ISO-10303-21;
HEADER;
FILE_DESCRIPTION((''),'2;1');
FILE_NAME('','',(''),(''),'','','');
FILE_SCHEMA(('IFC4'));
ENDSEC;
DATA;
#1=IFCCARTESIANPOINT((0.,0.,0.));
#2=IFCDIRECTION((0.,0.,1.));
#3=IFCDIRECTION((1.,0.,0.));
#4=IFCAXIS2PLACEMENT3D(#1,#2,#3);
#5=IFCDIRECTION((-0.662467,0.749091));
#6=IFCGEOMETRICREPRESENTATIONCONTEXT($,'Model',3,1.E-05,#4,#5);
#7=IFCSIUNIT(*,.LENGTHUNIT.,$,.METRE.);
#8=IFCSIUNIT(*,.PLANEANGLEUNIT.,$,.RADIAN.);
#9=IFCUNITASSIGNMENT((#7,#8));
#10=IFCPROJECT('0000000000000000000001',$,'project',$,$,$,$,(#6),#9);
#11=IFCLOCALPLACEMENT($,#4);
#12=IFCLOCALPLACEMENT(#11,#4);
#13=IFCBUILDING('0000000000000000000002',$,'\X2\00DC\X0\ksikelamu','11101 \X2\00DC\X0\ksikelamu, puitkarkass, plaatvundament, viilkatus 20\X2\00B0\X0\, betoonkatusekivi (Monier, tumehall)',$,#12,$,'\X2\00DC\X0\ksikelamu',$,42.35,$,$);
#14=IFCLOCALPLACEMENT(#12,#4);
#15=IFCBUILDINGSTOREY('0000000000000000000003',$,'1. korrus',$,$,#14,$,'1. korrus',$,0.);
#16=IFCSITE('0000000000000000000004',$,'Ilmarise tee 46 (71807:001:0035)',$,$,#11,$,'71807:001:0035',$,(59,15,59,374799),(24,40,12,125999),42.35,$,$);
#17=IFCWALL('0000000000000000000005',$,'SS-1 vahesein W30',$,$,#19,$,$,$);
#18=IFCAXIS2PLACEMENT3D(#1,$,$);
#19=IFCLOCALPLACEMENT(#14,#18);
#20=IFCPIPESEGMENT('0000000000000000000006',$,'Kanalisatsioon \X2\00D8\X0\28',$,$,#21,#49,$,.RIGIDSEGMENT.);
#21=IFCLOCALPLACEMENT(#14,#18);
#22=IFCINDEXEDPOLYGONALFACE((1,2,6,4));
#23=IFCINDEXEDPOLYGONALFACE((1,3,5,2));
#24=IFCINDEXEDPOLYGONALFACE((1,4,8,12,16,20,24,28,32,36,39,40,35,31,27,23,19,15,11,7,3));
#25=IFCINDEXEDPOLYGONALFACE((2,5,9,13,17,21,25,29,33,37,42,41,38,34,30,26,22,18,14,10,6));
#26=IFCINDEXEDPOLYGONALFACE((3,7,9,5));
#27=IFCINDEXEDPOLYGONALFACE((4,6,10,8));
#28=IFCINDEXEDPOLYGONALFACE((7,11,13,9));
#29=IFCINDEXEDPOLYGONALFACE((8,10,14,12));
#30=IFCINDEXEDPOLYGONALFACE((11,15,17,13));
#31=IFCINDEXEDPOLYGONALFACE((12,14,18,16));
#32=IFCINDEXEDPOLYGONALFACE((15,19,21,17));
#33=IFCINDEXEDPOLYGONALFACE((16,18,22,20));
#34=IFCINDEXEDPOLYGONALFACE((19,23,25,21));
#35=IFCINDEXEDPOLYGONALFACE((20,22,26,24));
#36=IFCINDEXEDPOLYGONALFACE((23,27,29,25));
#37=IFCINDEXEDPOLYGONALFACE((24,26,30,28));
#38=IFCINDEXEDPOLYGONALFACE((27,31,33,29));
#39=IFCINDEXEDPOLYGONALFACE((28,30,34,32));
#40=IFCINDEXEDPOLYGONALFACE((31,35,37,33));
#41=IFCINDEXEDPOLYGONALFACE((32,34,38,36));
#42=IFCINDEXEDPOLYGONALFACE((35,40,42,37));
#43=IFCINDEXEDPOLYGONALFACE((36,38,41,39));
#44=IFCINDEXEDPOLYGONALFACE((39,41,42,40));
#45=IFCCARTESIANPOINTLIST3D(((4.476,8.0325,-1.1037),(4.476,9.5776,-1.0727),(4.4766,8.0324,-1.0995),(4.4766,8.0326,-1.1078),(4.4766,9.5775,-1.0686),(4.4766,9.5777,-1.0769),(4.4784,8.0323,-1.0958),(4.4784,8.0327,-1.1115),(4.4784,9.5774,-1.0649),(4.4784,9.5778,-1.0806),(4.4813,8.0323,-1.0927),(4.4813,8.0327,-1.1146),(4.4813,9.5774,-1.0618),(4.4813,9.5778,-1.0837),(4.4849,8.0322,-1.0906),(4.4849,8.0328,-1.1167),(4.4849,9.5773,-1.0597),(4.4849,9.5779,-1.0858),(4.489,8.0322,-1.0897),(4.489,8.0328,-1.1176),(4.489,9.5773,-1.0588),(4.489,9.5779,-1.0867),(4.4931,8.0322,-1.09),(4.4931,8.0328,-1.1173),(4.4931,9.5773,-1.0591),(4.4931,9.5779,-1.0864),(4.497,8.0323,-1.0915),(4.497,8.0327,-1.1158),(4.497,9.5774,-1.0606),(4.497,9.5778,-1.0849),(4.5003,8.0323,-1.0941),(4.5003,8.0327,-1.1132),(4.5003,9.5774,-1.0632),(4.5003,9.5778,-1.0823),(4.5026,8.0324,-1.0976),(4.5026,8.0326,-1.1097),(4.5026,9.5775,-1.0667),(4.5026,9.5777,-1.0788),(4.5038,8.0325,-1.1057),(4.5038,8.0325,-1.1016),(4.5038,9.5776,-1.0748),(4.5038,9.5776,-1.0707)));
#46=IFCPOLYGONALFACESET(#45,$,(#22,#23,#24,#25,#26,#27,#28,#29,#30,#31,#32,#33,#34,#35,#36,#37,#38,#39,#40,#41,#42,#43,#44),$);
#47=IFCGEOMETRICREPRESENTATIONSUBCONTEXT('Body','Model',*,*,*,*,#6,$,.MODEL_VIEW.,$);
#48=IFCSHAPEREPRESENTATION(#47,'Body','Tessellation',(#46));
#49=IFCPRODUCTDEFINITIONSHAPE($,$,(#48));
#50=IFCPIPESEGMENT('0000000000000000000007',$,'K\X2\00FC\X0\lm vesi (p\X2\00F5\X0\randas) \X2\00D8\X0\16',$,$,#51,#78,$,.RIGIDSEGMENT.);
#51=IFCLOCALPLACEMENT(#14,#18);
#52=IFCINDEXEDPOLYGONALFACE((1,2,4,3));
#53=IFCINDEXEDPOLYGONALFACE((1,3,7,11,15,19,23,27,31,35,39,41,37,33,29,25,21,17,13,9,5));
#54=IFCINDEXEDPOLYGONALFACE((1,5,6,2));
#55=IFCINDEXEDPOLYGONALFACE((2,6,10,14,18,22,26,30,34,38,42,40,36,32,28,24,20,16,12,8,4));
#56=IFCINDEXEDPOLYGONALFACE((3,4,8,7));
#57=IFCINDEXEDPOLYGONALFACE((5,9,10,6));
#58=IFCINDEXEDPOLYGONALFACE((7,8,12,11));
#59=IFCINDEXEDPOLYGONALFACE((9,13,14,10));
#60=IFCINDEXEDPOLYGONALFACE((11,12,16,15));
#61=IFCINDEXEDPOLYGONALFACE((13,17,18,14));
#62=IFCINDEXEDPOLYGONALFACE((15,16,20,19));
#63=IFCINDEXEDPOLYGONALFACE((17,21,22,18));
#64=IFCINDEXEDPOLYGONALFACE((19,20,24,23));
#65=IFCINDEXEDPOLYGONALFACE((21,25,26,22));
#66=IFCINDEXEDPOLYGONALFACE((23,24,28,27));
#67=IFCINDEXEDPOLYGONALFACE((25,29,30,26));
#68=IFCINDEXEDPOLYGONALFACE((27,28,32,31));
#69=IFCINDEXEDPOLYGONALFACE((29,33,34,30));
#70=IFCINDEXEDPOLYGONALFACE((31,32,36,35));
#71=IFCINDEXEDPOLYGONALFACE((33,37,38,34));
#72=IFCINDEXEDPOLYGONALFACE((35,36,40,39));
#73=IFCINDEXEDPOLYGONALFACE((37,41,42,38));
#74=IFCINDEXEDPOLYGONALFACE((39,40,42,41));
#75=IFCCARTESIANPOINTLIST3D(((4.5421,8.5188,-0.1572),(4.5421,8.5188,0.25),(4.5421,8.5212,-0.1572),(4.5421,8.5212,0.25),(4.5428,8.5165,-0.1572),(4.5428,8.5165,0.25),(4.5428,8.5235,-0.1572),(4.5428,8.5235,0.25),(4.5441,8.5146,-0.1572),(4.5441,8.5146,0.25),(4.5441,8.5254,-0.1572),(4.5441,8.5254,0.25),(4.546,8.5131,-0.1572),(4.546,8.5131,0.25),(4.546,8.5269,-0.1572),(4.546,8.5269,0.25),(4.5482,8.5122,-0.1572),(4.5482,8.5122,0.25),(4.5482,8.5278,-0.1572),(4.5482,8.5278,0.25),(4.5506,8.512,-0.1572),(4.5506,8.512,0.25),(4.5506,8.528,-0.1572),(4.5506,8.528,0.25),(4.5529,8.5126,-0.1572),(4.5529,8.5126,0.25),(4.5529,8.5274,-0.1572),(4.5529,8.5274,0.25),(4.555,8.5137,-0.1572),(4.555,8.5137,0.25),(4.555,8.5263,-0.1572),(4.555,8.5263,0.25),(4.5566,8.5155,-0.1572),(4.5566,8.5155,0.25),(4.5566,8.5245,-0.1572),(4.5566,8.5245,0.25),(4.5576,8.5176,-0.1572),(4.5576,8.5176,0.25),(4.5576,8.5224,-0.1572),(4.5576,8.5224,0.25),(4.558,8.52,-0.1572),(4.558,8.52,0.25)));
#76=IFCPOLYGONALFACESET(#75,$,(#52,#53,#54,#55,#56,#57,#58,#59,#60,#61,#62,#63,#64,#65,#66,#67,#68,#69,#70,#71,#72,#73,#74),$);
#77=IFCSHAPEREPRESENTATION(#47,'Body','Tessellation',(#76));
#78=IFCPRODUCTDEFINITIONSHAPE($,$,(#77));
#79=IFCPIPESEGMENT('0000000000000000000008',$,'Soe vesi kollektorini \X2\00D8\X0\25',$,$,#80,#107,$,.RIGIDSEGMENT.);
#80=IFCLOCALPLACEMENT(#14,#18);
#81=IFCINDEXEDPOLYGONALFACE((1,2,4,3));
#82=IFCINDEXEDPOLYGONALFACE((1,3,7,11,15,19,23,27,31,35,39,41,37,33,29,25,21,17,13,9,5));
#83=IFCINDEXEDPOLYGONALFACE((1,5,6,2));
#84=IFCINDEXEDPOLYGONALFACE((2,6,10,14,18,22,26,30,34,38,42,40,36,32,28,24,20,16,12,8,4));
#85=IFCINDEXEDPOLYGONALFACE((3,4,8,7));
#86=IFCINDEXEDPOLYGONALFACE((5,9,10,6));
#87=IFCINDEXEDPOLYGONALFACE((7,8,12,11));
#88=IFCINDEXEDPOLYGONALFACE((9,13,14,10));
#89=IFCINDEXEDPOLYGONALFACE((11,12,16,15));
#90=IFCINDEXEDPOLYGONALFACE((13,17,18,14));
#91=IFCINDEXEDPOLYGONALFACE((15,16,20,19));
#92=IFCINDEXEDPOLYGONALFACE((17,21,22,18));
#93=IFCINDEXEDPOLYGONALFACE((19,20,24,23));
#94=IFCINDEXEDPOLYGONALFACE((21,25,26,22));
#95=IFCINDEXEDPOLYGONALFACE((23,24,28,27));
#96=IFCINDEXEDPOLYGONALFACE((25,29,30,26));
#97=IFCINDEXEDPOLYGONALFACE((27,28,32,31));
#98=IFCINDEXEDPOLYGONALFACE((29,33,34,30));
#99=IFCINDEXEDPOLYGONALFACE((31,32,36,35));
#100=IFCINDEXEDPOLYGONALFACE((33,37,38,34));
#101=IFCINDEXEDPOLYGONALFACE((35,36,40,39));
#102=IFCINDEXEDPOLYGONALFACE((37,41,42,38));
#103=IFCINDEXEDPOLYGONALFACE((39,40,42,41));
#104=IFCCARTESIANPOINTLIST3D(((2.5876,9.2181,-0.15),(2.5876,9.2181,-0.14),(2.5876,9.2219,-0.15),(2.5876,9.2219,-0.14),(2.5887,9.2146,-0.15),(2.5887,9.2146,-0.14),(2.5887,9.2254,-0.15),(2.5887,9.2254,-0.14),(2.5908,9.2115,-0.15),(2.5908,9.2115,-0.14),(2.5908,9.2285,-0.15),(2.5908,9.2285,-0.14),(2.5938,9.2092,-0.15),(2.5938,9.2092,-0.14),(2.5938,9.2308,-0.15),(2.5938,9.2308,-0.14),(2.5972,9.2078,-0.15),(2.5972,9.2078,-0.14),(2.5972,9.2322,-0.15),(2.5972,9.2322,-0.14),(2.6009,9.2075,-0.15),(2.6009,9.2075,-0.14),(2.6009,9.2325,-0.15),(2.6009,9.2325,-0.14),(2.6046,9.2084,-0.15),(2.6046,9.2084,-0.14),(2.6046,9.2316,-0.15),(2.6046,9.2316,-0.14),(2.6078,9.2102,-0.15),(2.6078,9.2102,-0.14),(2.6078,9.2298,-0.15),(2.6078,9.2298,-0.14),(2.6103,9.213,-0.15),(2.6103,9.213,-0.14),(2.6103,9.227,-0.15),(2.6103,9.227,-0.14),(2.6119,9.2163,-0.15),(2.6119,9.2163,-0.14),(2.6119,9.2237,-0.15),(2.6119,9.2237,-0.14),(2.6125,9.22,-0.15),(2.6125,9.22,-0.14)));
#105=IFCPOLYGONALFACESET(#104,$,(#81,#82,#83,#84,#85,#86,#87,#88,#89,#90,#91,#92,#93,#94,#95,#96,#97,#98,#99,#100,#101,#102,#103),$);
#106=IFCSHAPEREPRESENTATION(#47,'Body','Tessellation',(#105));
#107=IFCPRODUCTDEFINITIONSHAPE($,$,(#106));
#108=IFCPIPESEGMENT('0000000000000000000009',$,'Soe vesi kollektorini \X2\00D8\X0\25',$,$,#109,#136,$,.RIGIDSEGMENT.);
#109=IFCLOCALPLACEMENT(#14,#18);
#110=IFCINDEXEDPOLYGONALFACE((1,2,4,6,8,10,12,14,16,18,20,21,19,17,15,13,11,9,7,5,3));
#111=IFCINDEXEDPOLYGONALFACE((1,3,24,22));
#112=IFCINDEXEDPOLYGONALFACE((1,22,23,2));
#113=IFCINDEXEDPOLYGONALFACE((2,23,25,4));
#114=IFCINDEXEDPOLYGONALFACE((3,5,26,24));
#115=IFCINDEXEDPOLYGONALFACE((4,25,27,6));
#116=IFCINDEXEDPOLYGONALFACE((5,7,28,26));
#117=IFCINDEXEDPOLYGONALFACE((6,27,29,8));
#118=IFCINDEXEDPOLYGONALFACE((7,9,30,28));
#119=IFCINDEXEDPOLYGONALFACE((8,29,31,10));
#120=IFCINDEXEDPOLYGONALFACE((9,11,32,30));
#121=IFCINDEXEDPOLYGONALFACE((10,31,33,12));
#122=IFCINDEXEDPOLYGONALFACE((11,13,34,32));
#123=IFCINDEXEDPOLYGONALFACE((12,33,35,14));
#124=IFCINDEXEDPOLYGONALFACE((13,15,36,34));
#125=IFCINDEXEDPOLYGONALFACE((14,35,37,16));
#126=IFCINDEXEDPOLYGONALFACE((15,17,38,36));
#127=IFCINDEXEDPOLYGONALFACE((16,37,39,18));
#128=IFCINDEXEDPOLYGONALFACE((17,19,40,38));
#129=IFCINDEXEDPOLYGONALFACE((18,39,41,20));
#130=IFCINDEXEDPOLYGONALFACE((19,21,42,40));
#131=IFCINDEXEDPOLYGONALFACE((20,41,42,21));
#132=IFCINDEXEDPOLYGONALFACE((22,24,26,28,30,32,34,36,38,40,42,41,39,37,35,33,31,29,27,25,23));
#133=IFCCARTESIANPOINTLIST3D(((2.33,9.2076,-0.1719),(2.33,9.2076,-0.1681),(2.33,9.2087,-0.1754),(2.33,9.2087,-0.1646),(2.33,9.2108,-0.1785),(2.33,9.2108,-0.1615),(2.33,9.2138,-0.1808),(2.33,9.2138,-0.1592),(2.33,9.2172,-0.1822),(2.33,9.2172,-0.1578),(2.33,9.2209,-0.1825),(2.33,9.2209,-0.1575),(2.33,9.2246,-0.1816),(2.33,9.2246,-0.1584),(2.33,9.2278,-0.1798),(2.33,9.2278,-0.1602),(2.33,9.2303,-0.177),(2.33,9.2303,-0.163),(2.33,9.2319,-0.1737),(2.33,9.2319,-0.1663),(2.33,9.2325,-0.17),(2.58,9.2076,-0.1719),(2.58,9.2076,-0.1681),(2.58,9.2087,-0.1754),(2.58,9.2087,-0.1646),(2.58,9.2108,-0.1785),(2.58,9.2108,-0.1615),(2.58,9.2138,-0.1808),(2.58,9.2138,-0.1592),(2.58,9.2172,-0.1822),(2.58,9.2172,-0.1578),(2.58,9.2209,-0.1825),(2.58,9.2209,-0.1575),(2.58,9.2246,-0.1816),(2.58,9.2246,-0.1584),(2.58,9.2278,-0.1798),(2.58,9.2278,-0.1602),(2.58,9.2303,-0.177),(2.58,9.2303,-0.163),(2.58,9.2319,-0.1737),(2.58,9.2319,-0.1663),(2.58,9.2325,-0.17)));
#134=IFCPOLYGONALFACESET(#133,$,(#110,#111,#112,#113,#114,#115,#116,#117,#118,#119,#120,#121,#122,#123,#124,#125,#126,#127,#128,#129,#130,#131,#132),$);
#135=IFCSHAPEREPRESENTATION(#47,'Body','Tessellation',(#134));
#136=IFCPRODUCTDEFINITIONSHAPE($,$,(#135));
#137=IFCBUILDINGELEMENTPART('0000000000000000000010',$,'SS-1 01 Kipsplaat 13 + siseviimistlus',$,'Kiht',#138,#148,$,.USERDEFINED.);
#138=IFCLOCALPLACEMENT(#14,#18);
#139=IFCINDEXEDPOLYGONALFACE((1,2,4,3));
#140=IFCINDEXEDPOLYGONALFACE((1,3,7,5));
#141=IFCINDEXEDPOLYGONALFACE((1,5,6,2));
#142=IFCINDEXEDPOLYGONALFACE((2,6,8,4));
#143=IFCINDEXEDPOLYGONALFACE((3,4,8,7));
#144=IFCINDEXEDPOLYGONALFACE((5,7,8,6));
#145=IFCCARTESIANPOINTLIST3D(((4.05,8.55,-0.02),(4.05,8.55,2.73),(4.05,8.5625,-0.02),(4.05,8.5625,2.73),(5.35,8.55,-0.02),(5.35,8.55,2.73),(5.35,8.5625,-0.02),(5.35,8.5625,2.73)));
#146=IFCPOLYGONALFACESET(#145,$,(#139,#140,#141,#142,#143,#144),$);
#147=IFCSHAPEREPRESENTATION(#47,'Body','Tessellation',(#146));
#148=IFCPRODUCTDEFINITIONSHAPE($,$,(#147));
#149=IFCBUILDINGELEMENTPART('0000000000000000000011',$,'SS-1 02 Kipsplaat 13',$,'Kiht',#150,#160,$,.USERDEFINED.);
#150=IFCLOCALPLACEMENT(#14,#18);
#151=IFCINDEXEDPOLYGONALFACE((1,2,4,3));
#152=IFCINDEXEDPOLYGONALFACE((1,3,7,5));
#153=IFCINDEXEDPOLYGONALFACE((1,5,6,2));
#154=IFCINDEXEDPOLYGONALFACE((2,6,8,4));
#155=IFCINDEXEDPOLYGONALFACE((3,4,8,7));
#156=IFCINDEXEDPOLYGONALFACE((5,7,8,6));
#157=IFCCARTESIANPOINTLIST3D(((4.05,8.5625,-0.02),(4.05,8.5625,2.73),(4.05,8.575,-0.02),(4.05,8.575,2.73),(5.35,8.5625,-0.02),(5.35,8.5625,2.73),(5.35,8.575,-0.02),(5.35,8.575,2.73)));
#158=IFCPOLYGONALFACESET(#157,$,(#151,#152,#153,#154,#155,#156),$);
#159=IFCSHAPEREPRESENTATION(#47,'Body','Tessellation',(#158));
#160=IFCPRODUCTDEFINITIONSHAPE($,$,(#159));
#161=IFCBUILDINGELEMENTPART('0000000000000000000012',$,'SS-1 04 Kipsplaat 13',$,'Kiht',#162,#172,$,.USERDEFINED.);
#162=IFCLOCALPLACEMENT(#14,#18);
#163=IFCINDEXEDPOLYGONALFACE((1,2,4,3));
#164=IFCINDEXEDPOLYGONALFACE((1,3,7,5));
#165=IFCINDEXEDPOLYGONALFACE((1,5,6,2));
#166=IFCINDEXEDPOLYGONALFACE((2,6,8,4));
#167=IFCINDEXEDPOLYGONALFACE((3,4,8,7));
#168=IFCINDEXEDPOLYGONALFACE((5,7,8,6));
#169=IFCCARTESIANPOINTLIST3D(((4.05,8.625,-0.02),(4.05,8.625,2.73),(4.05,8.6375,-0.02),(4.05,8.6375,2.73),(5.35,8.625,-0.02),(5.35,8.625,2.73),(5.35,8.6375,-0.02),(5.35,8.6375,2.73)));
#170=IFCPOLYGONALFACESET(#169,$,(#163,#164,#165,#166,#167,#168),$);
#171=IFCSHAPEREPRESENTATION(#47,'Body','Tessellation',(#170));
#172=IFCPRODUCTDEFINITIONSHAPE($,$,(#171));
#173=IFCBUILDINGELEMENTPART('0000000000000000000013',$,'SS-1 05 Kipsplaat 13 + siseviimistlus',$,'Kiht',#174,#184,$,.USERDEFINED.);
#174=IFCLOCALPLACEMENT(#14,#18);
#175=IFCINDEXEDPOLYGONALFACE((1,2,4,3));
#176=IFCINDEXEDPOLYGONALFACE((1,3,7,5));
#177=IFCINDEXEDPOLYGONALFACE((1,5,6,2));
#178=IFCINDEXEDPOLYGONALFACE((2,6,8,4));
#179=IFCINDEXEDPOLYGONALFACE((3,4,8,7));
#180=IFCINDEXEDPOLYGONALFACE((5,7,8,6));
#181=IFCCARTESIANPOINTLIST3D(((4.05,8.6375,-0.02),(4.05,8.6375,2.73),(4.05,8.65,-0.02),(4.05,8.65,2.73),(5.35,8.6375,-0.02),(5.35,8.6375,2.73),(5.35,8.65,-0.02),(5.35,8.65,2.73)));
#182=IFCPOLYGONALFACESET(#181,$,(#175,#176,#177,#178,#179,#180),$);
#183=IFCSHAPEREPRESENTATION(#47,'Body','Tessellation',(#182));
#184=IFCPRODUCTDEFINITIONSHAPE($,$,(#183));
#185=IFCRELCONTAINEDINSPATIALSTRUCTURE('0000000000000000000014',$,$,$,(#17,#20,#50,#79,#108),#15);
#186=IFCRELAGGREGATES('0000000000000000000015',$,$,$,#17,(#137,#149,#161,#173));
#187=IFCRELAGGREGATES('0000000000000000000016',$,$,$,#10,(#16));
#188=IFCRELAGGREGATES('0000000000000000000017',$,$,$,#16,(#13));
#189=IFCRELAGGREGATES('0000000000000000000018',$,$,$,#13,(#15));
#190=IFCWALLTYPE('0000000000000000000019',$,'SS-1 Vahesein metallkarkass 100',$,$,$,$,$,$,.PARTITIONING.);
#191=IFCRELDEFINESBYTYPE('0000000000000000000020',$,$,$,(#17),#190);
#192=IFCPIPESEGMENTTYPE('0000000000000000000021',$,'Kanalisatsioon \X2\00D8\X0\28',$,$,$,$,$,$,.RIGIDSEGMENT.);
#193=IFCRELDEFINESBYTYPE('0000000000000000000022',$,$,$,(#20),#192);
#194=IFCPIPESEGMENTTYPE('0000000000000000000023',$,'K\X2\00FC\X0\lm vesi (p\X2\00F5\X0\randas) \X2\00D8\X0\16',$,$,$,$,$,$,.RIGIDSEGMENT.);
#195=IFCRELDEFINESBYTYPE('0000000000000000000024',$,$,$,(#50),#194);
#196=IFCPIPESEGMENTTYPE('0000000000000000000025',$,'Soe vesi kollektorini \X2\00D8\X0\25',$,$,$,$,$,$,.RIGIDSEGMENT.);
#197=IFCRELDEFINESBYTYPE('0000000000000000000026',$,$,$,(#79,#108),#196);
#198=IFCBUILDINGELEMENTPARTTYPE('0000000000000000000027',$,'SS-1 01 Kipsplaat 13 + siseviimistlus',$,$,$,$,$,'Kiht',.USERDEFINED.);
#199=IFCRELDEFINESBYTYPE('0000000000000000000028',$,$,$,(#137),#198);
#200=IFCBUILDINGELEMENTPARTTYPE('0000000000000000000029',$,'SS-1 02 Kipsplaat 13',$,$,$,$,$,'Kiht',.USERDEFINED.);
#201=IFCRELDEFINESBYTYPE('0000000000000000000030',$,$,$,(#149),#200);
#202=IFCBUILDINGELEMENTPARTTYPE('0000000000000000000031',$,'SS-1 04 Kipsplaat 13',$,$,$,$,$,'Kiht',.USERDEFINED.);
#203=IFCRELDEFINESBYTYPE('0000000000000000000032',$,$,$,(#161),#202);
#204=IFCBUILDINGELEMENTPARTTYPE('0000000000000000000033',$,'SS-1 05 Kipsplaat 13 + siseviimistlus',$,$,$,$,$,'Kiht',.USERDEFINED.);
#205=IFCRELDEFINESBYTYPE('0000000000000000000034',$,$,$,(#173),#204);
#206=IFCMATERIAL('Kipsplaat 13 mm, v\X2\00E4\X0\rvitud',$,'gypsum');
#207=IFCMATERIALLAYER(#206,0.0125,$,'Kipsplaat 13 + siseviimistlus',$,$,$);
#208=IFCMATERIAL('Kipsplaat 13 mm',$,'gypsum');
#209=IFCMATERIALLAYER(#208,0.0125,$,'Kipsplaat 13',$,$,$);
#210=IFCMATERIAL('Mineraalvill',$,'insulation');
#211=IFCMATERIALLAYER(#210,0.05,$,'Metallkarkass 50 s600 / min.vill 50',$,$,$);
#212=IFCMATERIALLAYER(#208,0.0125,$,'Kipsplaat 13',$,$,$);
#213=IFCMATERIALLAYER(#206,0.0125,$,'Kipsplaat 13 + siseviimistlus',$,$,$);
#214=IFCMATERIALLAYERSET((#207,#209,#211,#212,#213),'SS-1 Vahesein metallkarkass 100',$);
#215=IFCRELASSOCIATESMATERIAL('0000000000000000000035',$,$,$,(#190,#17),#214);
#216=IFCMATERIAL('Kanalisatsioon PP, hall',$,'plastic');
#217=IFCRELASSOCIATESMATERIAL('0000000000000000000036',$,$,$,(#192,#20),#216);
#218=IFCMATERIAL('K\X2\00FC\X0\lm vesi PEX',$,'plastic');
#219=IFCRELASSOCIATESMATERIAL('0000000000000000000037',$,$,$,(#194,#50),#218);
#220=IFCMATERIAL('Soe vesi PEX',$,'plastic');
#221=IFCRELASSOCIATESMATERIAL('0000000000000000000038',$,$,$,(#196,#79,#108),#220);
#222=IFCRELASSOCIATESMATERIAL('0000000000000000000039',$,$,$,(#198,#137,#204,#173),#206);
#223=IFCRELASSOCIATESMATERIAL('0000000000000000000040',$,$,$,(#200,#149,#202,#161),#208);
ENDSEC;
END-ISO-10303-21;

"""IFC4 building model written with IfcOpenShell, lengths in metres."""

from ifc_helpers import new_model, si_unit, direction, frame, origin_with_axes, place, context, subcontext, project, spatial, indexed_curve, circle, outline, extrude, material, layer, layer_set, layer_usage, type_object, element, aggregate, save


model = new_model("IFC4")

# Units and contexts
model_context = context("Model", 3, precision=1e-05, world=origin_with_axes(), true_north=direction((-0.662467, 0.749091)))
body_context = subcontext(model_context, "Body", "Model", "MODEL_VIEW")
ifc_project = project(units=[si_unit("LENGTHUNIT", "METRE"), si_unit("PLANEANGLEUNIT", "RADIAN")], contexts=[model_context])

# Site, building, storey
site_placement = place(None, origin_with_axes())
site = spatial("IfcSite", under=ifc_project, at=site_placement, Name="Ilmarise tee 46 (71807:001:0035)", LongName="71807:001:0035", RefLatitude=(59, 15, 59, 374799), RefLongitude=(24, 40, 12, 125999), RefElevation=42.35)
building_placement = place(site_placement, origin_with_axes())
building = spatial("IfcBuilding", under=site, at=building_placement, Name="Üksikelamu", Description="11101 Üksikelamu, puitkarkass, plaatvundament, viilkatus 20°, betoonkatusekivi (Monier, tumehall)", LongName="Üksikelamu", ElevationOfRefHeight=42.35)
storey_placement = place(building_placement, origin_with_axes())
storey = spatial("IfcBuildingStorey", under=building, at=storey_placement, Name="1. korrus", LongName="1. korrus", Elevation=0.0)

# Wall
ifc_material_1 = material(Name="Kipsplaat 13 mm, värvitud", Category="gypsum")
ifc_layer_1 = layer(ifc_material_1, 0.0125, Name="Kipsplaat 13 + siseviimistlus")
ifc_material_2 = material(Name="Kipsplaat 13 mm", Category="gypsum")
ifc_layer_2 = layer(ifc_material_2, 0.0125, Name="Kipsplaat 13")
ifc_material_3 = material(Name="Mineraalvill", Category="insulation")
ifc_layer_3 = layer(ifc_material_3, 0.05, Name="Metallkarkass 50 s600 / min.vill 50")
ifc_layer_4 = layer(ifc_material_2, 0.0125, Name="Kipsplaat 13")
ifc_layer_5 = layer(ifc_material_1, 0.0125, Name="Kipsplaat 13 + siseviimistlus")
ifc_layer_set = layer_set([ifc_layer_1, ifc_layer_2, ifc_layer_3, ifc_layer_4, ifc_layer_5], Name="SS-1 Vahesein metallkarkass 100")
ifc_layer_usage = layer_usage(ifc_layer_set, "AXIS2", "POSITIVE", 0.0)
wall_type = type_object("IfcWallType", Name="SS-1 Vahesein metallkarkass 100", PredefinedType="PARTITIONING", material=ifc_layer_set)
wall_placement = place(storey_placement, frame((4.05, 8.55, 0.0), z_axis=(0.0, 0.0, 1.0), x_axis=(1.0, 0.0, 0.0)))
wall = element("IfcWall", 1, at=wall_placement, inside=storey, type_object=wall_type, material=ifc_layer_usage, Name="SS-1 vahesein W30")

# Shared definitions
ifc_material_4 = material(Name="Kanalisatsioon PP, hall", Category="plastic")
ifc_material_5 = material(Name="Külm vesi PEX", Category="plastic")
ifc_material_6 = material(Name="Soe vesi PEX", Category="plastic")

# Pipe segments
pipe_segment_type_1 = type_object("IfcPipeSegmentType", Name="Kanalisatsioon Ø28", PredefinedType="RIGIDSEGMENT", material=ifc_material_4)
pipe_segment_1_placement = place(storey_placement, frame((4.49, 9.5776, -1.0727), z_axis=(0.0, -0.9998, -0.019996), x_axis=(-1.0, 0.0, 0.0)))
element("IfcPipeSegment", 2, at=pipe_segment_1_placement, inside=storey, type_object=pipe_segment_type_1, material=ifc_material_4, Name="Kanalisatsioon Ø28", PredefinedType="RIGIDSEGMENT", context=body_context, shape_type="SweptSolid", body=[
    extrude(circle(Radius=0.014), origin_with_axes(), (0.0, 0.0, 1.0), 1.5454),
])
pipe_segment_type_2 = type_object("IfcPipeSegmentType", Name="Külm vesi (põrandas) Ø16", PredefinedType="RIGIDSEGMENT", material=ifc_material_5)
pipe_segment_2_placement = place(storey_placement, frame((4.55, 8.52, -0.1572), z_axis=(0.0, 0.0, 1.0), x_axis=(1.0, 0.0, 0.0)))
element("IfcPipeSegment", 3, at=pipe_segment_2_placement, inside=storey, type_object=pipe_segment_type_2, material=ifc_material_5, Name="Külm vesi (põrandas) Ø16", PredefinedType="RIGIDSEGMENT", context=body_context, shape_type="SweptSolid", body=[
    extrude(circle(Radius=0.008), origin_with_axes(), (0.0, 0.0, 1.0), 0.4072),
])
pipe_segment_type_3 = type_object("IfcPipeSegmentType", Name="Soe vesi kollektorini Ø25", PredefinedType="RIGIDSEGMENT", material=ifc_material_6)
pipe_segment_3_placement = place(storey_placement, frame((2.6, 9.22, -0.14), z_axis=(0.0, 0.0, -1.0), x_axis=(1.0, 0.0, 0.0)))
element("IfcPipeSegment", 4, at=pipe_segment_3_placement, inside=storey, type_object=pipe_segment_type_3, material=ifc_material_6, Name="Soe vesi kollektorini Ø25", PredefinedType="RIGIDSEGMENT", context=body_context, shape_type="SweptSolid", body=[
    extrude(circle(Radius=0.0125), origin_with_axes(), (0.0, 0.0, 1.0), 0.01),
])
pipe_segment_4_placement = place(storey_placement, frame((2.58, 9.22, -0.17), z_axis=(-1.0, 0.0, 0.0), x_axis=(0.0, 1.0, 0.0)))
element("IfcPipeSegment", 5, at=pipe_segment_4_placement, inside=storey, type_object=pipe_segment_type_3, material=ifc_material_6, Name="Soe vesi kollektorini Ø25", PredefinedType="RIGIDSEGMENT", context=body_context, shape_type="SweptSolid", body=[
    extrude(circle(Radius=0.0125), origin_with_axes(), (0.0, 0.0, 1.0), 0.25),
])

# Building element parts
building_element_part_type_1 = type_object("IfcBuildingElementPartType", Name="SS-1 01 Kipsplaat 13 + siseviimistlus", ElementType="Kiht", PredefinedType="USERDEFINED", material=ifc_material_1)
building_element_part_1_placement = place(wall_placement, origin_with_axes())
building_element_part_1 = element("IfcBuildingElementPart", 6, at=building_element_part_1_placement, type_object=building_element_part_type_1, material=ifc_material_1, Name="SS-1 01 Kipsplaat 13 + siseviimistlus", ObjectType="Kiht", PredefinedType="USERDEFINED", context=body_context, shape_type="SweptSolid", body=[
    extrude(outline(indexed_curve([(1.3, -0.02), (1.3, 2.73), (0.0, 2.73), (0.0, -0.02), (1.3, -0.02)], self_intersect=False)), frame((0.0, 0.0125, 0.0), z_axis=(0.0, -1.0, 0.0), x_axis=(1.0, 0.0, 0.0)), (0.0, 0.0, 1.0), 0.0125),
])
building_element_part_type_2 = type_object("IfcBuildingElementPartType", Name="SS-1 02 Kipsplaat 13", ElementType="Kiht", PredefinedType="USERDEFINED", material=ifc_material_2)
building_element_part_2_placement = place(wall_placement, origin_with_axes())
building_element_part_2 = element("IfcBuildingElementPart", 7, at=building_element_part_2_placement, type_object=building_element_part_type_2, material=ifc_material_2, Name="SS-1 02 Kipsplaat 13", ObjectType="Kiht", PredefinedType="USERDEFINED", context=body_context, shape_type="SweptSolid", body=[
    extrude(outline(indexed_curve([(1.3, -0.02), (1.3, 2.73), (0.0, 2.73), (0.0, -0.02), (1.3, -0.02)], self_intersect=False)), frame((0.0, 0.025, 0.0), z_axis=(0.0, -1.0, 0.0), x_axis=(1.0, 0.0, 0.0)), (0.0, 0.0, 1.0), 0.0125),
])
building_element_part_type_3 = type_object("IfcBuildingElementPartType", Name="SS-1 04 Kipsplaat 13", ElementType="Kiht", PredefinedType="USERDEFINED", material=ifc_material_2)
building_element_part_3_placement = place(wall_placement, origin_with_axes())
building_element_part_3 = element("IfcBuildingElementPart", 8, at=building_element_part_3_placement, type_object=building_element_part_type_3, material=ifc_material_2, Name="SS-1 04 Kipsplaat 13", ObjectType="Kiht", PredefinedType="USERDEFINED", context=body_context, shape_type="SweptSolid", body=[
    extrude(outline(indexed_curve([(1.3, -0.02), (1.3, 2.73), (0.0, 2.73), (0.0, -0.02), (1.3, -0.02)], self_intersect=False)), frame((0.0, 0.0875, 0.0), z_axis=(0.0, -1.0, 0.0), x_axis=(1.0, 0.0, 0.0)), (0.0, 0.0, 1.0), 0.0125),
])
building_element_part_type_4 = type_object("IfcBuildingElementPartType", Name="SS-1 05 Kipsplaat 13 + siseviimistlus", ElementType="Kiht", PredefinedType="USERDEFINED", material=ifc_material_1)
building_element_part_4_placement = place(wall_placement, origin_with_axes())
building_element_part_4 = element("IfcBuildingElementPart", 9, at=building_element_part_4_placement, type_object=building_element_part_type_4, material=ifc_material_1, Name="SS-1 05 Kipsplaat 13 + siseviimistlus", ObjectType="Kiht", PredefinedType="USERDEFINED", context=body_context, shape_type="SweptSolid", body=[
    extrude(outline(indexed_curve([(1.3, -0.02), (1.3, 2.73), (0.0, 2.73), (0.0, -0.02), (1.3, -0.02)], self_intersect=False)), frame((0.0, 0.1, 0.0), z_axis=(0.0, -1.0, 0.0), x_axis=(1.0, 0.0, 0.0)), (0.0, 0.0, 1.0), 0.0125),
])
aggregate(wall, [building_element_part_1, building_element_part_2, building_element_part_3, building_element_part_4])

save(model, "model.ifc")
